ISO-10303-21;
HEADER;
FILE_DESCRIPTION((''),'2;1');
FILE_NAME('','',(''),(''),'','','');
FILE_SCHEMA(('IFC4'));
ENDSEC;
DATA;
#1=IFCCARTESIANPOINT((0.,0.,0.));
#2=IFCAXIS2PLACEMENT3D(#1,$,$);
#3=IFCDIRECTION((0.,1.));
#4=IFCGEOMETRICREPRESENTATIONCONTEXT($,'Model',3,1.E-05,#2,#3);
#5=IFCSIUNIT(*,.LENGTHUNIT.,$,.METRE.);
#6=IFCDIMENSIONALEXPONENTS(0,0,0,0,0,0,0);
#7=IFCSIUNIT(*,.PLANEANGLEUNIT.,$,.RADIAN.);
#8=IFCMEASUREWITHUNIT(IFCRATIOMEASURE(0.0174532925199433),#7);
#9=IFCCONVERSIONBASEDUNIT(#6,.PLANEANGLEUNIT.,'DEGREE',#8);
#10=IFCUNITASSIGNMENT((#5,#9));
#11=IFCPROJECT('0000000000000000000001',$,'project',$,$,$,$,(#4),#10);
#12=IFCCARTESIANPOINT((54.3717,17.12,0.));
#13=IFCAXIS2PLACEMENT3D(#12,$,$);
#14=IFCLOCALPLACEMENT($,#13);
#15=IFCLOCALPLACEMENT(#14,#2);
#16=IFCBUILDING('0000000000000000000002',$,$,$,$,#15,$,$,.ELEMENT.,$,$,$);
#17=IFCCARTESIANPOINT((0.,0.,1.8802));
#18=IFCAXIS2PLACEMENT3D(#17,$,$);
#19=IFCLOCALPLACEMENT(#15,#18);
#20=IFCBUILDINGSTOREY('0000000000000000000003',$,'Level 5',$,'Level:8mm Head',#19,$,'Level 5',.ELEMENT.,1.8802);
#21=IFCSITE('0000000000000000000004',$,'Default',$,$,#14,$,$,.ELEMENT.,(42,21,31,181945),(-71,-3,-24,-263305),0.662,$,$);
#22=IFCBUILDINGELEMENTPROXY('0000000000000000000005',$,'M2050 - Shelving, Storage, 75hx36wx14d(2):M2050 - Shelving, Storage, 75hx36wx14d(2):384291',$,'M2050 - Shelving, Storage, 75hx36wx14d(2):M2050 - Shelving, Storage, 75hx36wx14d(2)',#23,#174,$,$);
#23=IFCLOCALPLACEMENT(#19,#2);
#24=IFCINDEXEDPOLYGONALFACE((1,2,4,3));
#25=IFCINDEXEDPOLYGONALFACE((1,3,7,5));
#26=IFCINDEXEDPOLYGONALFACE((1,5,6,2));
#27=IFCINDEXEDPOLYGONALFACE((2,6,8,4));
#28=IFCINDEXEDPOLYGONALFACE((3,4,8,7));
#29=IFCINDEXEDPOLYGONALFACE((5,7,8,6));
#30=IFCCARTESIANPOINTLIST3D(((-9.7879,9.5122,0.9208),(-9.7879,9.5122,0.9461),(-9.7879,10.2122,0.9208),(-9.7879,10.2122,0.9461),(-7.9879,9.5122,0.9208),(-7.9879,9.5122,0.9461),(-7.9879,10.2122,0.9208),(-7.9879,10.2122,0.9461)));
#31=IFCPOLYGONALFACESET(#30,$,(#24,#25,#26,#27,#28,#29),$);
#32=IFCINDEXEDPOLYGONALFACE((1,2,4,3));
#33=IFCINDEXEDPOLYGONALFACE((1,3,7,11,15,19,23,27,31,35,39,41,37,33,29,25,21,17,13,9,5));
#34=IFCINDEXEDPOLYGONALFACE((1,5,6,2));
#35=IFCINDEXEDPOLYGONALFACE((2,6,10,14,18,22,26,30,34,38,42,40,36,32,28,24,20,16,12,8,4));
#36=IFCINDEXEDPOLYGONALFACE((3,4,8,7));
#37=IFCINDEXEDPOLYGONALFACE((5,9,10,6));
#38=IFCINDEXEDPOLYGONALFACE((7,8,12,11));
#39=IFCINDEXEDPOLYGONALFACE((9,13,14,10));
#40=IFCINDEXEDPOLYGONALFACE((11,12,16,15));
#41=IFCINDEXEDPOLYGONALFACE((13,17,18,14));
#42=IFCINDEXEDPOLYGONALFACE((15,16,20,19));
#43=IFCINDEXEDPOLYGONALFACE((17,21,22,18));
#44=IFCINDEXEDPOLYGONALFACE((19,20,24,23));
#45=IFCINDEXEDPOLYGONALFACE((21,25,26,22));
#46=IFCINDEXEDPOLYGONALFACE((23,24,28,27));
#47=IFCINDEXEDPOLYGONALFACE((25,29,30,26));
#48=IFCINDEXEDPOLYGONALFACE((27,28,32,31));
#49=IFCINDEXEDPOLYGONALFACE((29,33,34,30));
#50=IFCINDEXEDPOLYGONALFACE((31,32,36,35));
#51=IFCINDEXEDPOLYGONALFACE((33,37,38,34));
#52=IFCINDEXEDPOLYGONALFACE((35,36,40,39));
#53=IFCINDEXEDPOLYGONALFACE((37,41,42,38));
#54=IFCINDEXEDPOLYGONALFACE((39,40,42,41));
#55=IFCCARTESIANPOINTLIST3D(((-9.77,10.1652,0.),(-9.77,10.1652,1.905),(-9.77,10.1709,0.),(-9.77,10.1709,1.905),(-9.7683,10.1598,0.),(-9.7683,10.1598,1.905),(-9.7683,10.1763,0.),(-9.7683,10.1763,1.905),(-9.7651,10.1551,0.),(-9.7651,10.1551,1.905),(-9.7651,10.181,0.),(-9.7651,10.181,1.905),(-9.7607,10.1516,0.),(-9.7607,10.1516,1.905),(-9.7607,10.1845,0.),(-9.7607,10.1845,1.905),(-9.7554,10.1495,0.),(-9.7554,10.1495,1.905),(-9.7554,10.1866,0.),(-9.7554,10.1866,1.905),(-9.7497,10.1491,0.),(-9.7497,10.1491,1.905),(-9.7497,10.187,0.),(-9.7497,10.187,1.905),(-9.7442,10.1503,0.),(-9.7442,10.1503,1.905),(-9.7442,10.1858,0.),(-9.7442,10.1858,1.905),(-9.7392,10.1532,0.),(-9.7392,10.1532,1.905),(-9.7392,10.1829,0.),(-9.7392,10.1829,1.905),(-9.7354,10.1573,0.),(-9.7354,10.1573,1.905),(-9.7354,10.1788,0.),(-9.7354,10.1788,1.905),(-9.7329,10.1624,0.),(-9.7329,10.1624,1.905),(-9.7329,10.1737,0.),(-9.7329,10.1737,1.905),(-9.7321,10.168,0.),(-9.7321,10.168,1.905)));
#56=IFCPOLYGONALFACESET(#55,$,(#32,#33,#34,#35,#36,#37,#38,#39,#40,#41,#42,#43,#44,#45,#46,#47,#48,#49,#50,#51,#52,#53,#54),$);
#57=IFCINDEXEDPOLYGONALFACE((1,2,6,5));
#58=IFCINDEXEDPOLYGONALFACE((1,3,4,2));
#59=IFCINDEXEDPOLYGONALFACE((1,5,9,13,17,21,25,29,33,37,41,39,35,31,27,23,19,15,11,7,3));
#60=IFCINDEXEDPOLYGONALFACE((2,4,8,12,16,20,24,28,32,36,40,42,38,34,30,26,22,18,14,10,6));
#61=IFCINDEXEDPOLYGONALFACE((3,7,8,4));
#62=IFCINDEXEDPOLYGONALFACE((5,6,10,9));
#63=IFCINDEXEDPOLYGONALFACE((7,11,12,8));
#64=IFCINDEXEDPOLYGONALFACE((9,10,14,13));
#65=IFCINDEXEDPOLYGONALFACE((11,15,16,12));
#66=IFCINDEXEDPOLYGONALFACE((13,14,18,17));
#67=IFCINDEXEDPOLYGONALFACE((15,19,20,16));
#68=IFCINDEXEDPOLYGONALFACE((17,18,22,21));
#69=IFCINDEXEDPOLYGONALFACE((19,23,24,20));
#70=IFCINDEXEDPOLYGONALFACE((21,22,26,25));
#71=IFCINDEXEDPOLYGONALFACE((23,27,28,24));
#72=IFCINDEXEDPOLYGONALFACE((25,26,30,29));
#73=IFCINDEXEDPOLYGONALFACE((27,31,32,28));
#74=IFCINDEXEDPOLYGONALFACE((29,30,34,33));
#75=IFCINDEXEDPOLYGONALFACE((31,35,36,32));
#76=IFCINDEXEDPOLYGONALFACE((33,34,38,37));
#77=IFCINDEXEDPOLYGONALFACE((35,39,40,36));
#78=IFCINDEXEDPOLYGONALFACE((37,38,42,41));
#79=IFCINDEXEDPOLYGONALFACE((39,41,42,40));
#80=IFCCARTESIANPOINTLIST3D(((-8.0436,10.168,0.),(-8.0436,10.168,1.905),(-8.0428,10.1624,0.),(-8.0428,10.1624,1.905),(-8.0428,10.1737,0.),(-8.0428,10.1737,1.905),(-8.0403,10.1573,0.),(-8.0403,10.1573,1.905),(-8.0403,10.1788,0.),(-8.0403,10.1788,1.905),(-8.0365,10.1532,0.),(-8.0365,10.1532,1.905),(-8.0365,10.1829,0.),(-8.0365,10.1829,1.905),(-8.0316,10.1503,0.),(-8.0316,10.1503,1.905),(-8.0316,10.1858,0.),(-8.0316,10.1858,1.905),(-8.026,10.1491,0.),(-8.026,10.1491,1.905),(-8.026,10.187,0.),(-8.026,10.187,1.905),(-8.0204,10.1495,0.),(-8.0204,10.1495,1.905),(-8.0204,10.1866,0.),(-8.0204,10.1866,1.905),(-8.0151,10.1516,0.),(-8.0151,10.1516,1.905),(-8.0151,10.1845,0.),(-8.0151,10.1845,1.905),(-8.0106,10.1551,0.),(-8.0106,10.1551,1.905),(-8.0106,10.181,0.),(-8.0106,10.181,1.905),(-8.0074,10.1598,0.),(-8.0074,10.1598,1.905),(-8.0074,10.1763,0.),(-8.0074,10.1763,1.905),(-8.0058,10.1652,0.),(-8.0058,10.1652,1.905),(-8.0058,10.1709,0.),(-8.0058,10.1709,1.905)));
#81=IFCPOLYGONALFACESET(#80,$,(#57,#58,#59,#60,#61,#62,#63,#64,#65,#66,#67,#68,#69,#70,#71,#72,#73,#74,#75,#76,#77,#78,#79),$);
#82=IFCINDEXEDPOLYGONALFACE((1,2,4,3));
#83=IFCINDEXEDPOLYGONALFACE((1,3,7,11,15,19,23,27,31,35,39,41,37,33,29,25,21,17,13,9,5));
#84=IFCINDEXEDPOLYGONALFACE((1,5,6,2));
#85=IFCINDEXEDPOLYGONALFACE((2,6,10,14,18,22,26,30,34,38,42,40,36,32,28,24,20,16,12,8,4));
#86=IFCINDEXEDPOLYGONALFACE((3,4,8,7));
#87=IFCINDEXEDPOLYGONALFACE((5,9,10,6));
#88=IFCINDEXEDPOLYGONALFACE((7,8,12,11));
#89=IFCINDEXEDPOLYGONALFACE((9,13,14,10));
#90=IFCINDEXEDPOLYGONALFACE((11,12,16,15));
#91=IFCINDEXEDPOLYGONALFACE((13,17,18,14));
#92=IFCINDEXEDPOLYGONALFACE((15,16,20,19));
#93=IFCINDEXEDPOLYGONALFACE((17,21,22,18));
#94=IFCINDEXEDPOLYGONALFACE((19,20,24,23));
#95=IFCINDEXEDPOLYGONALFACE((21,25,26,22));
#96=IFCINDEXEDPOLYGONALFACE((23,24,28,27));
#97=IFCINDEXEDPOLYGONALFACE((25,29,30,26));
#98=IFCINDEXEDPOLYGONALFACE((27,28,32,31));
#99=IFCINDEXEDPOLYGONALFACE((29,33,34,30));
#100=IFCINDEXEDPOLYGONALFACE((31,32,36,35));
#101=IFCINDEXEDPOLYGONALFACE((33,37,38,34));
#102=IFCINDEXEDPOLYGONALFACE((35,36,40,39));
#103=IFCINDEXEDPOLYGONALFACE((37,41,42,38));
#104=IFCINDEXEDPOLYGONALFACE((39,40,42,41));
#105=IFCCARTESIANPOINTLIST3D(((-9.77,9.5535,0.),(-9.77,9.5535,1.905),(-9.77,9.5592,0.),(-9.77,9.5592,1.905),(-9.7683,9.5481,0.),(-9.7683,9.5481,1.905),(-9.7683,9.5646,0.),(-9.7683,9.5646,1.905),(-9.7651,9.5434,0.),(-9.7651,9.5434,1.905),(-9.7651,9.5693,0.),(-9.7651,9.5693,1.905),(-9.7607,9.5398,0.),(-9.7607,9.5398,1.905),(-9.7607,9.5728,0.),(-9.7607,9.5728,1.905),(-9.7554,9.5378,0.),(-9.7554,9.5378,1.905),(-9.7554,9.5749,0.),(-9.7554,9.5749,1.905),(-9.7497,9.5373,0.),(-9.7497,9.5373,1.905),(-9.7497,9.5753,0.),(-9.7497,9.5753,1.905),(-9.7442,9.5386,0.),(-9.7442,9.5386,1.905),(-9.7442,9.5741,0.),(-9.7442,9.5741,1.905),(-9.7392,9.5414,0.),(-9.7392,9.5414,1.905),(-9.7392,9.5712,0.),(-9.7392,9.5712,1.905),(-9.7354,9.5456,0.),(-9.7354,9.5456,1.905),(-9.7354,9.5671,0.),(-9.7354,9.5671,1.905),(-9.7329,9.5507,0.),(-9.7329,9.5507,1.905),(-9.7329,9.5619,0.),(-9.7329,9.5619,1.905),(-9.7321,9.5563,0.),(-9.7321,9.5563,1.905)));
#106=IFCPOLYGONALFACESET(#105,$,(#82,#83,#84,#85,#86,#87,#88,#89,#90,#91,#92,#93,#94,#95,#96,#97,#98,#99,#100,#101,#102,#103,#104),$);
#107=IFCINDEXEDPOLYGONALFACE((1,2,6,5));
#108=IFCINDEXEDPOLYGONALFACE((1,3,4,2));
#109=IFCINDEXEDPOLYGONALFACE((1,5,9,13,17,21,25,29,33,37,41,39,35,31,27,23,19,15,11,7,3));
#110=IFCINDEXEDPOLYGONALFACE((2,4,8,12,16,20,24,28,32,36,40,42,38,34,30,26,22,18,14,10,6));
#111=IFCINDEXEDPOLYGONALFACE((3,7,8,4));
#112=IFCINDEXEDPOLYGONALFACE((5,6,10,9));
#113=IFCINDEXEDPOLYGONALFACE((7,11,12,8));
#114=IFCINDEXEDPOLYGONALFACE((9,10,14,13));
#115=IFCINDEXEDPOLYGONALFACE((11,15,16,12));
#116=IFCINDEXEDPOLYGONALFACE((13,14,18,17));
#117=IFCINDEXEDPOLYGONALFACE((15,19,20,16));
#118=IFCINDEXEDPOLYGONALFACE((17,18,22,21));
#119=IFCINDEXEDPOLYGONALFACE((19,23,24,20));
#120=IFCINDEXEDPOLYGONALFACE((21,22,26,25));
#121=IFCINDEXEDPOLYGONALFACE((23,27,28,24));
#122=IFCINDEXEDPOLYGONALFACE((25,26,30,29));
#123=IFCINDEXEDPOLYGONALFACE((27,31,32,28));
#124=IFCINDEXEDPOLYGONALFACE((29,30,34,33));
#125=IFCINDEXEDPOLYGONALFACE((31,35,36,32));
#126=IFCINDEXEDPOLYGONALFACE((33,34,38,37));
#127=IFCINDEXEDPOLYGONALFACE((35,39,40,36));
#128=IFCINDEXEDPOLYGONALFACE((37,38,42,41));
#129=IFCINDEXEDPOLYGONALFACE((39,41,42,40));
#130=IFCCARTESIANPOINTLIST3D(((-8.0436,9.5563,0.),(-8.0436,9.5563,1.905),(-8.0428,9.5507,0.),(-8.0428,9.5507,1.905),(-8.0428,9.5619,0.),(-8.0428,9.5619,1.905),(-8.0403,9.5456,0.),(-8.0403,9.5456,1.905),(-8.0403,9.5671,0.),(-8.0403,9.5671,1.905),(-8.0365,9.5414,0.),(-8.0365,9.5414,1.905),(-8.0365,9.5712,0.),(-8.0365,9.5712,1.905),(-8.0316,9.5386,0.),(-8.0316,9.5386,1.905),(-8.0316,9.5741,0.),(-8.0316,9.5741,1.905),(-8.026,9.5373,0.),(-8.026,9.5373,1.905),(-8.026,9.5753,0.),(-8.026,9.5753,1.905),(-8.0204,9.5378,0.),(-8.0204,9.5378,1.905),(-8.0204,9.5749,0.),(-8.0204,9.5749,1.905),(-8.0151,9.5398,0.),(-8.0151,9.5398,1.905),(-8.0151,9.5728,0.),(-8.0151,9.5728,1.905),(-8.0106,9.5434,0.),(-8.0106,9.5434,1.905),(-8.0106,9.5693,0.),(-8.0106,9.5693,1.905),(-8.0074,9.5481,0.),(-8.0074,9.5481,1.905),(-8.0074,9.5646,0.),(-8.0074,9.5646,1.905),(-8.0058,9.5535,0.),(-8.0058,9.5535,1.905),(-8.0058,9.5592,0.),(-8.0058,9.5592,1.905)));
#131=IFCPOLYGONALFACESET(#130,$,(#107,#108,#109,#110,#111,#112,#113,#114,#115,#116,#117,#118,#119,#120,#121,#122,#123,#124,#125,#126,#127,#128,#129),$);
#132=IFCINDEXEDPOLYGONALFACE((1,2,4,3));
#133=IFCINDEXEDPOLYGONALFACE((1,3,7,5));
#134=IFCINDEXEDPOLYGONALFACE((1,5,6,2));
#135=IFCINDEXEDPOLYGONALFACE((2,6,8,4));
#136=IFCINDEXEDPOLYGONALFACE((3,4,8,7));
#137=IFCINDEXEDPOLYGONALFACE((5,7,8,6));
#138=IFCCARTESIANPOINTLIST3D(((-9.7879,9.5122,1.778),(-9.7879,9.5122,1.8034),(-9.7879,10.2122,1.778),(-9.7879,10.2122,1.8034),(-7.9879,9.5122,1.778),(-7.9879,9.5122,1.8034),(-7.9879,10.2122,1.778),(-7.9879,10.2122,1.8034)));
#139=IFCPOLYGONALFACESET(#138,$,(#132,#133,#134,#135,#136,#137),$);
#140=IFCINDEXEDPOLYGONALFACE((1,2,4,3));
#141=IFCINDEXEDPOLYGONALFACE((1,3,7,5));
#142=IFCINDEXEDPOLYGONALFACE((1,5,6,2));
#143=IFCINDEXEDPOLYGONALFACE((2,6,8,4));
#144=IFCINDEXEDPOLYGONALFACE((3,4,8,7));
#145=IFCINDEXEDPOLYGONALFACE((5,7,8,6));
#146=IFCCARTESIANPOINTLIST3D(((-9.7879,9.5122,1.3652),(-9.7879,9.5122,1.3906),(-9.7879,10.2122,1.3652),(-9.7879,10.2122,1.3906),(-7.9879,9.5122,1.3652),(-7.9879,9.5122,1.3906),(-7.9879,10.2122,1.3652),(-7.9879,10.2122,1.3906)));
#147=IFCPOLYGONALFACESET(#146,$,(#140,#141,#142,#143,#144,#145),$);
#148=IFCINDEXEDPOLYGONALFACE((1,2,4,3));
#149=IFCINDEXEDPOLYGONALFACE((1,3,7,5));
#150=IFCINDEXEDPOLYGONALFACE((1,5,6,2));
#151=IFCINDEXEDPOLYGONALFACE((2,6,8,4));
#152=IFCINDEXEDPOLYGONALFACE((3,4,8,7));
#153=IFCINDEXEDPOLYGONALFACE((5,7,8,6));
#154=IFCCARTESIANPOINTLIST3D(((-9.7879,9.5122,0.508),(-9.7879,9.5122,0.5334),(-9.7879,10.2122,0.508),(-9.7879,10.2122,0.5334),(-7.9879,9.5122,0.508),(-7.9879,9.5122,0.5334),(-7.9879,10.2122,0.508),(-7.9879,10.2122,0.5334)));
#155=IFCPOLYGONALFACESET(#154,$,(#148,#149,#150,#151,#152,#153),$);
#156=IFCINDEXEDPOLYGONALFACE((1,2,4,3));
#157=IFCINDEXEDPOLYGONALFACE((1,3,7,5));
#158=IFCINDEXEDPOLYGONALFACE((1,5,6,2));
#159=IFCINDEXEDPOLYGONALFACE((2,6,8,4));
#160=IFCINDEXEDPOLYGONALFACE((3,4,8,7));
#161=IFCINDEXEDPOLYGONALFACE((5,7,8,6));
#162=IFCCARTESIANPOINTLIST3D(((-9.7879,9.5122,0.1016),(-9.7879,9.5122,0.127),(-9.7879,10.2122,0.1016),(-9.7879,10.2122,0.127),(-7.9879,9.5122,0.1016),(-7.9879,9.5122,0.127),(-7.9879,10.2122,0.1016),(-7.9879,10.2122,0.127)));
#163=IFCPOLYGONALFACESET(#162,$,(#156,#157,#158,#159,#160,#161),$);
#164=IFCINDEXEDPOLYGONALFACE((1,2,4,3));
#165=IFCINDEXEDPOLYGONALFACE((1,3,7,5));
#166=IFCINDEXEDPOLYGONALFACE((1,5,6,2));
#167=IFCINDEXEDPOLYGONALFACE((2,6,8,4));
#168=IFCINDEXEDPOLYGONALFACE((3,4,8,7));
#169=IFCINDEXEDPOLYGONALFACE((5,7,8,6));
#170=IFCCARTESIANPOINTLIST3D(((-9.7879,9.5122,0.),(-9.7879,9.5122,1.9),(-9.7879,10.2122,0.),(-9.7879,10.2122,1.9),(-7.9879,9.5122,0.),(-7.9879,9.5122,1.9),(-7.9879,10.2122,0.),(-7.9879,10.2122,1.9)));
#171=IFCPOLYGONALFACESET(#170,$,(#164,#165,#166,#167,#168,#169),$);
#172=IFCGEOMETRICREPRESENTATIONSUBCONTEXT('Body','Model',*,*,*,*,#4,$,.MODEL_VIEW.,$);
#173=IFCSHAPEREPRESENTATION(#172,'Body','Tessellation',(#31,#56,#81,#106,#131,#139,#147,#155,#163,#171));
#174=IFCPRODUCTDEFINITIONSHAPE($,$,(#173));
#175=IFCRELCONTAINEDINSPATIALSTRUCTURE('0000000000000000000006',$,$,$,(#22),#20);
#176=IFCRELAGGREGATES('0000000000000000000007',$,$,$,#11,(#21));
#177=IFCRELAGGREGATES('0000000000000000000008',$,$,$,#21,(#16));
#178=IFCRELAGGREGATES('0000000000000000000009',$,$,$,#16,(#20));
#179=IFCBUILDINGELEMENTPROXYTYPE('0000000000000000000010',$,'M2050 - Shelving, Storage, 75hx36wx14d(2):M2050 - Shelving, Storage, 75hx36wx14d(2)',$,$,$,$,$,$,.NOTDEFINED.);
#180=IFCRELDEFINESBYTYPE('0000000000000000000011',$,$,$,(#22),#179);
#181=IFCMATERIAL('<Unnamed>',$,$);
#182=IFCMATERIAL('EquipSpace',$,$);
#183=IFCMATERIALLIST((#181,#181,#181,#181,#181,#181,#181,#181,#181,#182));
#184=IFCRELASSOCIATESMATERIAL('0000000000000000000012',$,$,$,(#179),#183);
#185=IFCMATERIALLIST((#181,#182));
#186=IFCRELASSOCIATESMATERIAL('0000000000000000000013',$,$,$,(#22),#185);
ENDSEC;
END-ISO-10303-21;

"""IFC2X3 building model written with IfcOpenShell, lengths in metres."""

from ifc_helpers import new_model, entity, si_unit, converted_unit, direction, frame, frame_2d, origin, origin_2d_with_axis, place, context, subcontext, project, spatial, rectangle, circle, extrude, source, transform, mapped, material, material_list, type_object, type_shapes, element, save


model = new_model("IFC2X3")

# Units and contexts
model_context = context("Model", 3, precision=1e-05, world=origin(), true_north=direction((0.0, 1.0)))
body_context = subcontext(model_context, "Body", "Model", "MODEL_VIEW")
ifc_project = project(units=[si_unit("LENGTHUNIT", "METRE"), converted_unit("PLANEANGLEUNIT", "DEGREE", entity("IfcRatioMeasure", 0.0174532925199433), si_unit("PLANEANGLEUNIT", "RADIAN"), dimensions=[0, 0, 0, 0, 0, 0, 0])], contexts=[model_context])

# Site, building, storey
site_placement = place(None, frame((54.3717, 17.12, 0.0)))
site = spatial("IfcSite", under=ifc_project, at=site_placement, Name="Default", CompositionType="ELEMENT", RefLatitude=(42, 21, 31, 181945), RefLongitude=(-71, -3, -24, -263305), RefElevation=0.662)
building_placement = place(site_placement, origin())
building = spatial("IfcBuilding", under=site, at=building_placement, CompositionType="ELEMENT")
storey_placement = place(building_placement, frame((0.0, 0.0, 1.8802)))
storey = spatial("IfcBuildingStorey", under=building, at=storey_placement, Name="Level 5", ObjectType="Level:8mm Head", LongName="Level 5", CompositionType="ELEMENT", Elevation=1.8802)

# Building element proxy
ifc_material_1 = material(Name="<Unnamed>")
ifc_material_2 = material(Name="EquipSpace")
ifc_material_list_1 = material_list([ifc_material_1, ifc_material_1, ifc_material_1, ifc_material_1, ifc_material_1, ifc_material_1, ifc_material_1, ifc_material_1, ifc_material_1, ifc_material_2])
building_element_proxy_type = type_object("IfcBuildingElementProxyType", Name="M2050 - Shelving, Storage, 75hx36wx14d(2):M2050 - Shelving, Storage, 75hx36wx14d(2)", PredefinedType="NOTDEFINED", material=ifc_material_list_1)
shared_shape = source(origin(), body_context, "Body", "SweptSolid", [
    extrude(rectangle(XDim=1.8, YDim=0.7, at=origin_2d_with_axis()), frame((0.0, 0.0, 0.9207), z_axis=(0.0, 0.0, 1.0), x_axis=(-1.0, 0.0, 0.0)), (0.0, 0.0, 1.0), 0.0254),
    extrude(circle(Radius=0.0191, at=origin_2d_with_axis()), frame((0.8633, -0.3059, 0.0), z_axis=(0.0, 0.0, 1.0), x_axis=(-1.0, 0.0, 0.0)), (0.0, 0.0, 1.0), 1.905),
    extrude(circle(Radius=0.0191, at=origin_2d_with_axis()), frame((-0.8633, -0.3059, 0.0)), (0.0, 0.0, 1.0), 1.905),
    extrude(circle(Radius=0.0191, at=origin_2d_with_axis()), frame((0.8633, 0.3059, 0.0), z_axis=(0.0, 0.0, 1.0), x_axis=(-1.0, 0.0, 0.0)), (0.0, 0.0, 1.0), 1.905),
    extrude(circle(Radius=0.0191, at=origin_2d_with_axis()), frame((-0.8633, 0.3059, 0.0)), (0.0, 0.0, 1.0), 1.905),
    extrude(rectangle(XDim=1.8, YDim=0.7, at=origin_2d_with_axis()), frame((0.0, 0.0, 1.778), z_axis=(0.0, 0.0, 1.0), x_axis=(-1.0, 0.0, 0.0)), (0.0, 0.0, 1.0), 0.0254),
    extrude(rectangle(XDim=1.8, YDim=0.7, at=origin_2d_with_axis()), frame((0.0, 0.0, 1.3653), z_axis=(0.0, 0.0, 1.0), x_axis=(-1.0, 0.0, 0.0)), (0.0, 0.0, 1.0), 0.0254),
    extrude(rectangle(XDim=1.8, YDim=0.7, at=origin_2d_with_axis()), frame((0.0, 0.0, 0.508), z_axis=(0.0, 0.0, 1.0), x_axis=(-1.0, 0.0, 0.0)), (0.0, 0.0, 1.0), 0.0254),
    extrude(rectangle(XDim=1.8, YDim=0.7, at=origin_2d_with_axis()), frame((0.0, 0.0, 0.1016), z_axis=(0.0, 0.0, 1.0), x_axis=(-1.0, 0.0, 0.0)), (0.0, 0.0, 1.0), 0.0254),
    extrude(rectangle(XDim=0.7, YDim=1.8, at=frame_2d((0.0, 0.18), x_axis=(1.0, 0.0))), frame((-0.18, 0.0, 0.0), z_axis=(0.0, 0.0, 1.0), x_axis=(0.0, -1.0, 0.0)), (0.0, 0.0, 1.0), 1.9),
])
type_shapes(building_element_proxy_type, [shared_shape])
ifc_material_list_2 = material_list([ifc_material_1, ifc_material_2])
proxy_1_placement = place(storey_placement, frame((-8.8879, 9.8622, 0.0), z_axis=(0.0, 0.0, 1.0), x_axis=(-1.0, 0.0, 0.0)))
element("IfcBuildingElementProxy", 1, at=proxy_1_placement, inside=storey, type_object=building_element_proxy_type, material=ifc_material_list_2, Name="M2050 - Shelving, Storage, 75hx36wx14d(2):M2050 - Shelving, Storage, 75hx36wx14d(2):384291", ObjectType="M2050 - Shelving, Storage, 75hx36wx14d(2):M2050 - Shelving, Storage, 75hx36wx14d(2)", context=body_context, shape_type="MappedRepresentation", body=[
    mapped(shared_shape, transform((0.0, 0.0, 0.0), scale=1.0)),
])

save(model, "model.ifc")
